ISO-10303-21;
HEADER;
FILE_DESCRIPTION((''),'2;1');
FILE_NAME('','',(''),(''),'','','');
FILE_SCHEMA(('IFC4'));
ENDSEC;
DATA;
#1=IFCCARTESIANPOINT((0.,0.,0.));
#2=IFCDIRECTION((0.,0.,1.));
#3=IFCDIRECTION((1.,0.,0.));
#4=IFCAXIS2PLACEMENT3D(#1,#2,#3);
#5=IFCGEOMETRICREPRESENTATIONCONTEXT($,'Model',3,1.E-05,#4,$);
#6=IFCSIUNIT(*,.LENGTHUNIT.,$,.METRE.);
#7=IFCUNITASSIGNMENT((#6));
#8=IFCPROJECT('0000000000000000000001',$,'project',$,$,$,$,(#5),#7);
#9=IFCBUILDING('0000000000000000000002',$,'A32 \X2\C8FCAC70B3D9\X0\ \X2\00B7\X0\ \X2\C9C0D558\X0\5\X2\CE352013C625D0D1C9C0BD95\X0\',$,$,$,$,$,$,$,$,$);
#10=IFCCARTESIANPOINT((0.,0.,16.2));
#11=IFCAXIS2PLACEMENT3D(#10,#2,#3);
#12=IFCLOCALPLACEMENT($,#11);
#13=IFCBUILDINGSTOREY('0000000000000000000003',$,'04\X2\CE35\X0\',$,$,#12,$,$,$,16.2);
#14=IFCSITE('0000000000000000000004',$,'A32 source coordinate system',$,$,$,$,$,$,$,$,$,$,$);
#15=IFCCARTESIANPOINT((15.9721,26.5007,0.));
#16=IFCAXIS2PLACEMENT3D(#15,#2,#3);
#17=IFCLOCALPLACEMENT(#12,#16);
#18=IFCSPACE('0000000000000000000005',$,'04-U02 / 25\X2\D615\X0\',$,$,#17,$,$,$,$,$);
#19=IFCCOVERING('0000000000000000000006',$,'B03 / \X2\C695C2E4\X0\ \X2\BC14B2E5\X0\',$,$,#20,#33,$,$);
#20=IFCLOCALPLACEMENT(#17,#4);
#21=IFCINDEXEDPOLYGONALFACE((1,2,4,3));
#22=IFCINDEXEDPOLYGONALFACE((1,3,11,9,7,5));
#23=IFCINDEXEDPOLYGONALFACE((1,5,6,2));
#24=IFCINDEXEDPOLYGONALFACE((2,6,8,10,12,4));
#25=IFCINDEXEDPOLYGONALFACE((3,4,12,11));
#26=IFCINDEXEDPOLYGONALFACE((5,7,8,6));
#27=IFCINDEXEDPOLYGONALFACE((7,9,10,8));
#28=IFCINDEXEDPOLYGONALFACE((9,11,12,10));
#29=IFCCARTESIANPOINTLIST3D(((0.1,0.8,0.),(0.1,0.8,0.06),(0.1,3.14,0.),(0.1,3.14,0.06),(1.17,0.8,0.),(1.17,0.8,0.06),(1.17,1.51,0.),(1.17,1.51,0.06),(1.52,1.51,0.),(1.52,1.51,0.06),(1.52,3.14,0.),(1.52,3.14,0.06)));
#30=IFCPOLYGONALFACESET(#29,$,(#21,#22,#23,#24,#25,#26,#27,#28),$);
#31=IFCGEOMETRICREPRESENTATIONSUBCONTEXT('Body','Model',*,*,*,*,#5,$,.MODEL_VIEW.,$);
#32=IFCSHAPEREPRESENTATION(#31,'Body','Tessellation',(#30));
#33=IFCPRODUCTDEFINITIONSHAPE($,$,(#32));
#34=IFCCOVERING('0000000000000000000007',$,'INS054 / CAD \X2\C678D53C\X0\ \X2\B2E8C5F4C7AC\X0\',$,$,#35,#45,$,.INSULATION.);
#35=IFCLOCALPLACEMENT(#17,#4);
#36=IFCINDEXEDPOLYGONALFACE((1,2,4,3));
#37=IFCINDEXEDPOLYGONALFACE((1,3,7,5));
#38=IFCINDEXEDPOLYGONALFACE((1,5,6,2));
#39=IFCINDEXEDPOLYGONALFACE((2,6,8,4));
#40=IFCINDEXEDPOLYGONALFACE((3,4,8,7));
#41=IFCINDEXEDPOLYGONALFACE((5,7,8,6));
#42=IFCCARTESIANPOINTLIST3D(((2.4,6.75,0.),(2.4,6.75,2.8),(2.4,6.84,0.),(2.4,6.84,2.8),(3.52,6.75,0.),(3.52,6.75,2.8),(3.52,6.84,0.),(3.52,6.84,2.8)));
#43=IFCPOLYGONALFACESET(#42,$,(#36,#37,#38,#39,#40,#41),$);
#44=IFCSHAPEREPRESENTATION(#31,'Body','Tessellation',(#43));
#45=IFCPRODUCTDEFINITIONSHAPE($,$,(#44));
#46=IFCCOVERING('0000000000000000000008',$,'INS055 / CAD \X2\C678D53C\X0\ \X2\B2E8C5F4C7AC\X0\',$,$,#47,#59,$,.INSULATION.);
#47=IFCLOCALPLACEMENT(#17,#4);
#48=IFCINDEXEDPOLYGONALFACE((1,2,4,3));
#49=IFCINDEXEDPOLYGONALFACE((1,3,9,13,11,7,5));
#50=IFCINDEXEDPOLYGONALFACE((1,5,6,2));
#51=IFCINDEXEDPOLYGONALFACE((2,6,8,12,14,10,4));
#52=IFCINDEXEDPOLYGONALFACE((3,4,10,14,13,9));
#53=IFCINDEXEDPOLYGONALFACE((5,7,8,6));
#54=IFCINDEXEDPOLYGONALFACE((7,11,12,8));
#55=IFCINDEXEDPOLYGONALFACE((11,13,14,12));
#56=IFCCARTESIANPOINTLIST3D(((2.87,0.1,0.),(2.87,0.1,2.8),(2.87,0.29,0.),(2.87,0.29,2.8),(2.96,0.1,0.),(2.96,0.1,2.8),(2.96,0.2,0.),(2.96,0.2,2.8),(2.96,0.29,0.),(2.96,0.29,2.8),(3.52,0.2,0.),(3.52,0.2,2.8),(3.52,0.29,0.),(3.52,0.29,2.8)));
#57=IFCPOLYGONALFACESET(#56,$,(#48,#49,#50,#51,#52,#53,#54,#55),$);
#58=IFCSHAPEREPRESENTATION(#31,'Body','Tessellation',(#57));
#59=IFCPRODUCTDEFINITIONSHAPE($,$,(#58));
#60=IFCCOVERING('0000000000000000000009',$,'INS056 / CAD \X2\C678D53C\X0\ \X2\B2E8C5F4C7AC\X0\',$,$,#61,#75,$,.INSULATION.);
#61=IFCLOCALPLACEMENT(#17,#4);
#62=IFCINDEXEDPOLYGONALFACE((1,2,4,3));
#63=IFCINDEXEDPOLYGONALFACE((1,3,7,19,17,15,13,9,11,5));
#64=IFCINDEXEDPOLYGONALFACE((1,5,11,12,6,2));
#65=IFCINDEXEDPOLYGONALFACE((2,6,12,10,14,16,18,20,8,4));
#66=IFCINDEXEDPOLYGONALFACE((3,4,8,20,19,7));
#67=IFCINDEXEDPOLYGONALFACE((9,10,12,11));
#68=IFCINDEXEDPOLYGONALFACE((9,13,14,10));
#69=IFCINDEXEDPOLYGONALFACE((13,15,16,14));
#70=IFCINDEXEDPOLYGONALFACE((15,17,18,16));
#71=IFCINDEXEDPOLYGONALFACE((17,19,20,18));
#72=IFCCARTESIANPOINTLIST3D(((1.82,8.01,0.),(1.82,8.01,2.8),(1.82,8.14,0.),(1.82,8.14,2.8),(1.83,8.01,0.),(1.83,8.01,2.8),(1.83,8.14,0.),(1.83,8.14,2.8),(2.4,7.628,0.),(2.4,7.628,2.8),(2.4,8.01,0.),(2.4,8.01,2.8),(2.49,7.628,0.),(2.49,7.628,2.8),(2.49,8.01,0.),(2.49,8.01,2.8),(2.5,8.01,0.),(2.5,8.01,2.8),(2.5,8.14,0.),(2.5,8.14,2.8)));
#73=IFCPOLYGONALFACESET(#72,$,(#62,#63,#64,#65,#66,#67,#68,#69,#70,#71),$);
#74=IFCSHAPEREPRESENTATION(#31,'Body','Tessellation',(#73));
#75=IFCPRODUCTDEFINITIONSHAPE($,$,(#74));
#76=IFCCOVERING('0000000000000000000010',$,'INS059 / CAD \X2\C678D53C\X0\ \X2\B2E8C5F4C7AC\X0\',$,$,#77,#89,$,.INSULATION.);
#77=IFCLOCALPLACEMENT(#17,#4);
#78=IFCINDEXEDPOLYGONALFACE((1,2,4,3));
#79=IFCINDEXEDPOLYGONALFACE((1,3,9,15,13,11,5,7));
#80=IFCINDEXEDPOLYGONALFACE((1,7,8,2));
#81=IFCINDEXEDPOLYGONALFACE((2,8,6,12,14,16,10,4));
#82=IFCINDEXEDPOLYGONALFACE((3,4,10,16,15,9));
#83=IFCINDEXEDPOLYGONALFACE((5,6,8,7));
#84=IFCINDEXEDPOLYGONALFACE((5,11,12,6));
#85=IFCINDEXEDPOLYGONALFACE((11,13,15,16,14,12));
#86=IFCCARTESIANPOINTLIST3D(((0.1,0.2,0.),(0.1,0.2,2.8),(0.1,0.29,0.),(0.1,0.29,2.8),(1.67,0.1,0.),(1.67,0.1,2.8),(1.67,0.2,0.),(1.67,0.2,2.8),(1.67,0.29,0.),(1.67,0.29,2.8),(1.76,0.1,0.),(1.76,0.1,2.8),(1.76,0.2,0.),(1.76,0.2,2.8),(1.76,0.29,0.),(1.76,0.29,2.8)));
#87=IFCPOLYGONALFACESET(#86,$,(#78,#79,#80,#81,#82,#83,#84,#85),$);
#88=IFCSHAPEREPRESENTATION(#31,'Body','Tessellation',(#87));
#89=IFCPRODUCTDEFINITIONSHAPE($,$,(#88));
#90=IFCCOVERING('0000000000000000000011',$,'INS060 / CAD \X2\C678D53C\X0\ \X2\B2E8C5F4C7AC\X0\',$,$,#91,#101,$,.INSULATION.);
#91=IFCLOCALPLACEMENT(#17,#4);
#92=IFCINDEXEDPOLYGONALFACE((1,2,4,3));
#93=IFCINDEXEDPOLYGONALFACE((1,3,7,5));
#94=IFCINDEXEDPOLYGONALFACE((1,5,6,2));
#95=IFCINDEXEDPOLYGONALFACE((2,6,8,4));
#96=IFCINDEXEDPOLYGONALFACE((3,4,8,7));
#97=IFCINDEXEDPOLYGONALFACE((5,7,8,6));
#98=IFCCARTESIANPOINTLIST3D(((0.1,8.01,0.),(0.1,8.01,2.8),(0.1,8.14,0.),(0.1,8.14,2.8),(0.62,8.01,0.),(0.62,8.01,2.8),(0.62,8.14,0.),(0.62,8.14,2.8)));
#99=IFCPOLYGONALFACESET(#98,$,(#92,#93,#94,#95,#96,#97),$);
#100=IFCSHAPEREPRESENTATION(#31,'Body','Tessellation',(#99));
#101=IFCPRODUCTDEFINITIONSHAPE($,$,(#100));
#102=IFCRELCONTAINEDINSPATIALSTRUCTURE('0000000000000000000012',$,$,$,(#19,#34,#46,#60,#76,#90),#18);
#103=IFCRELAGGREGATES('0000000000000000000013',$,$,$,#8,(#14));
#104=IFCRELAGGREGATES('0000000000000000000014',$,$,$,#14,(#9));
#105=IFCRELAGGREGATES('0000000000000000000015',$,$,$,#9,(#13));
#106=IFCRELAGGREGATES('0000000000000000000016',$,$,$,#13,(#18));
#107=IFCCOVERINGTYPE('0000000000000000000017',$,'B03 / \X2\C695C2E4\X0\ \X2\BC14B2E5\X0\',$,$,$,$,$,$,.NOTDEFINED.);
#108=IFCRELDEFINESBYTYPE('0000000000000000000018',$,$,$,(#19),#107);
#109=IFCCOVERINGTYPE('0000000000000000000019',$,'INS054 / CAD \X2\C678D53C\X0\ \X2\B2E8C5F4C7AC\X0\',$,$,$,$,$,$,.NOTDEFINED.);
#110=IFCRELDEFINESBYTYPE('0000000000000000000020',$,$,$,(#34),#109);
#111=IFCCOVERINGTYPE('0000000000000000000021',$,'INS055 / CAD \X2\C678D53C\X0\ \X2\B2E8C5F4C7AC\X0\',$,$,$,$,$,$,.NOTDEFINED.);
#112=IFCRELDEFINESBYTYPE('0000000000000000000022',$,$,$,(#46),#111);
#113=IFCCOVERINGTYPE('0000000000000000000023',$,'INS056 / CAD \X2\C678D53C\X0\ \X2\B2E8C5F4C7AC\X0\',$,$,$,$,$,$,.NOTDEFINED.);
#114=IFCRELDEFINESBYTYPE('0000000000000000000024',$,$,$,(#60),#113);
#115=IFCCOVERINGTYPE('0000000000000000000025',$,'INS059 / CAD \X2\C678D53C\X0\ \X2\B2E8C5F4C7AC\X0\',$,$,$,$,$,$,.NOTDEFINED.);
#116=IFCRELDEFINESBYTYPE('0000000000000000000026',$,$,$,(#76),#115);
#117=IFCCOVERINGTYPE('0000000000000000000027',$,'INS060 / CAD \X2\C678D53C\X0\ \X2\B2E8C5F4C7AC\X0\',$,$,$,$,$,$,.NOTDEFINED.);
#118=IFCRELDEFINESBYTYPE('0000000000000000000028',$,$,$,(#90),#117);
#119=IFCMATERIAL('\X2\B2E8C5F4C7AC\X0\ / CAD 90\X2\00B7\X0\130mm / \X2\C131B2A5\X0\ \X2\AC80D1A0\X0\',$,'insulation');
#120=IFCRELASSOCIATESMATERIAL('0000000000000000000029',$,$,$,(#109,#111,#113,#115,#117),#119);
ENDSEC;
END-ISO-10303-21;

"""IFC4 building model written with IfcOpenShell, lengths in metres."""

from ifc_helpers import new_model, si_unit, frame, origin, origin_with_axes, place, context, subcontext, project, spatial, polyline, outline, extrude, source, transform, mapped, material, type_object, type_shapes, element, save


model = new_model("IFC4")

# Units and contexts
model_context = context("Model", 3, precision=1e-05, world=origin_with_axes())
body_context = subcontext(model_context, "Body", "Model", "MODEL_VIEW")
ifc_project = project(units=[si_unit("LENGTHUNIT", "METRE")], contexts=[model_context])

# Site, building, storey, space
storey_placement = place(None, frame((0.0, 0.0, 16.2), z_axis=(0.0, 0.0, 1.0), x_axis=(1.0, 0.0, 0.0)))
space_placement = place(storey_placement, frame((15.9721, 26.5007, 0.0), z_axis=(0.0, 0.0, 1.0), x_axis=(1.0, 0.0, 0.0)))
site = spatial("IfcSite", under=ifc_project, Name="A32 source coordinate system")
building = spatial("IfcBuilding", under=site, Name="A32 주거동 · 지하5층–옥탑지붕")
storey = spatial("IfcBuildingStorey", under=building, at=storey_placement, Name="04층", Elevation=16.2)
space = spatial("IfcSpace", under=storey, at=space_placement, Name="04-U02 / 25형")

# Coverings
covering_type_1 = type_object("IfcCoveringType", Name="B03 / 욕실 바닥", PredefinedType="NOTDEFINED")
shared_shape_1 = source(origin(), body_context, "Body", "SweptSolid", [
    extrude(outline(polyline([(1.17, 1.51), (1.17, 0.8), (0.1, 0.8), (0.1, 3.14), (1.52, 3.14), (1.52, 1.51), (1.17, 1.51)])), origin(), (0.0, 0.0, 1.0), 0.06),
])
type_shapes(covering_type_1, [shared_shape_1])
covering_1_placement = place(space_placement, origin_with_axes())
element("IfcCovering", 1, at=covering_1_placement, inside=space, type_object=covering_type_1, Name="B03 / 욕실 바닥", context=body_context, shape_type="MappedRepresentation", body=[
    mapped(shared_shape_1, transform((0.0, 0.0, 0.0), scale=1.0)),
])
ifc_material = material(Name="단열재 / CAD 90·130mm / 성능 검토", Category="insulation")
covering_type_2 = type_object("IfcCoveringType", Name="INS054 / CAD 외피 단열재", PredefinedType="NOTDEFINED", material=ifc_material)
shared_shape_2 = source(origin(), body_context, "Body", "SweptSolid", [
    extrude(outline(polyline([(2.4, 6.84), (3.52, 6.84), (3.52, 6.75), (2.4, 6.75), (2.4, 6.84)])), origin(), (0.0, 0.0, 1.0), 2.8),
])
type_shapes(covering_type_2, [shared_shape_2])
covering_2_placement = place(space_placement, origin_with_axes())
element("IfcCovering", 2, at=covering_2_placement, inside=space, type_object=covering_type_2, Name="INS054 / CAD 외피 단열재", PredefinedType="INSULATION", context=body_context, shape_type="MappedRepresentation", body=[
    mapped(shared_shape_2, transform((0.0, 0.0, 0.0), scale=1.0)),
])
covering_type_3 = type_object("IfcCoveringType", Name="INS055 / CAD 외피 단열재", PredefinedType="NOTDEFINED", material=ifc_material)
shared_shape_3 = source(origin(), body_context, "Body", "SweptSolid", [
    extrude(outline(polyline([(2.87, 0.29), (2.96, 0.29), (3.52, 0.29), (3.52, 0.2), (2.96, 0.2), (2.96, 0.1), (2.87, 0.1), (2.87, 0.29)])), origin(), (0.0, 0.0, 1.0), 2.8),
])
type_shapes(covering_type_3, [shared_shape_3])
covering_3_placement = place(space_placement, origin_with_axes())
element("IfcCovering", 3, at=covering_3_placement, inside=space, type_object=covering_type_3, Name="INS055 / CAD 외피 단열재", PredefinedType="INSULATION", context=body_context, shape_type="MappedRepresentation", body=[
    mapped(shared_shape_3, transform((0.0, 0.0, 0.0), scale=1.0)),
])
covering_type_4 = type_object("IfcCoveringType", Name="INS056 / CAD 외피 단열재", PredefinedType="NOTDEFINED", material=ifc_material)
shared_shape_4 = source(origin(), body_context, "Body", "SweptSolid", [
    extrude(outline(polyline([(2.49, 7.628), (2.4, 7.628), (2.4, 8.01), (1.83, 8.01), (1.82, 8.01), (1.82, 8.14), (1.83, 8.14), (2.5, 8.14), (2.5, 8.01), (2.49, 8.01), (2.49, 7.628)])), origin(), (0.0, 0.0, 1.0), 2.8),
])
type_shapes(covering_type_4, [shared_shape_4])
covering_4_placement = place(space_placement, origin_with_axes())
element("IfcCovering", 4, at=covering_4_placement, inside=space, type_object=covering_type_4, Name="INS056 / CAD 외피 단열재", PredefinedType="INSULATION", context=body_context, shape_type="MappedRepresentation", body=[
    mapped(shared_shape_4, transform((0.0, 0.0, 0.0), scale=1.0)),
])
covering_type_5 = type_object("IfcCoveringType", Name="INS059 / CAD 외피 단열재", PredefinedType="NOTDEFINED", material=ifc_material)
shared_shape_5 = source(origin(), body_context, "Body", "SweptSolid", [
    extrude(outline(polyline([(1.76, 0.1), (1.67, 0.1), (1.67, 0.2), (0.1, 0.2), (0.1, 0.29), (1.67, 0.29), (1.76, 0.29), (1.76, 0.2), (1.76, 0.1)])), origin(), (0.0, 0.0, 1.0), 2.8),
])
type_shapes(covering_type_5, [shared_shape_5])
covering_5_placement = place(space_placement, origin_with_axes())
element("IfcCovering", 5, at=covering_5_placement, inside=space, type_object=covering_type_5, Name="INS059 / CAD 외피 단열재", PredefinedType="INSULATION", context=body_context, shape_type="MappedRepresentation", body=[
    mapped(shared_shape_5, transform((0.0, 0.0, 0.0), scale=1.0)),
])
covering_type_6 = type_object("IfcCoveringType", Name="INS060 / CAD 외피 단열재", PredefinedType="NOTDEFINED", material=ifc_material)
shared_shape_6 = source(origin(), body_context, "Body", "SweptSolid", [
    extrude(outline(polyline([(0.1, 8.01), (0.1, 8.14), (0.62, 8.14), (0.62, 8.01), (0.1, 8.01)])), origin(), (0.0, 0.0, 1.0), 2.8),
])
type_shapes(covering_type_6, [shared_shape_6])
covering_6_placement = place(space_placement, origin_with_axes())
element("IfcCovering", 6, at=covering_6_placement, inside=space, type_object=covering_type_6, Name="INS060 / CAD 외피 단열재", PredefinedType="INSULATION", context=body_context, shape_type="MappedRepresentation", body=[
    mapped(shared_shape_6, transform((0.0, 0.0, 0.0), scale=1.0)),
])

save(model, "model.ifc")
